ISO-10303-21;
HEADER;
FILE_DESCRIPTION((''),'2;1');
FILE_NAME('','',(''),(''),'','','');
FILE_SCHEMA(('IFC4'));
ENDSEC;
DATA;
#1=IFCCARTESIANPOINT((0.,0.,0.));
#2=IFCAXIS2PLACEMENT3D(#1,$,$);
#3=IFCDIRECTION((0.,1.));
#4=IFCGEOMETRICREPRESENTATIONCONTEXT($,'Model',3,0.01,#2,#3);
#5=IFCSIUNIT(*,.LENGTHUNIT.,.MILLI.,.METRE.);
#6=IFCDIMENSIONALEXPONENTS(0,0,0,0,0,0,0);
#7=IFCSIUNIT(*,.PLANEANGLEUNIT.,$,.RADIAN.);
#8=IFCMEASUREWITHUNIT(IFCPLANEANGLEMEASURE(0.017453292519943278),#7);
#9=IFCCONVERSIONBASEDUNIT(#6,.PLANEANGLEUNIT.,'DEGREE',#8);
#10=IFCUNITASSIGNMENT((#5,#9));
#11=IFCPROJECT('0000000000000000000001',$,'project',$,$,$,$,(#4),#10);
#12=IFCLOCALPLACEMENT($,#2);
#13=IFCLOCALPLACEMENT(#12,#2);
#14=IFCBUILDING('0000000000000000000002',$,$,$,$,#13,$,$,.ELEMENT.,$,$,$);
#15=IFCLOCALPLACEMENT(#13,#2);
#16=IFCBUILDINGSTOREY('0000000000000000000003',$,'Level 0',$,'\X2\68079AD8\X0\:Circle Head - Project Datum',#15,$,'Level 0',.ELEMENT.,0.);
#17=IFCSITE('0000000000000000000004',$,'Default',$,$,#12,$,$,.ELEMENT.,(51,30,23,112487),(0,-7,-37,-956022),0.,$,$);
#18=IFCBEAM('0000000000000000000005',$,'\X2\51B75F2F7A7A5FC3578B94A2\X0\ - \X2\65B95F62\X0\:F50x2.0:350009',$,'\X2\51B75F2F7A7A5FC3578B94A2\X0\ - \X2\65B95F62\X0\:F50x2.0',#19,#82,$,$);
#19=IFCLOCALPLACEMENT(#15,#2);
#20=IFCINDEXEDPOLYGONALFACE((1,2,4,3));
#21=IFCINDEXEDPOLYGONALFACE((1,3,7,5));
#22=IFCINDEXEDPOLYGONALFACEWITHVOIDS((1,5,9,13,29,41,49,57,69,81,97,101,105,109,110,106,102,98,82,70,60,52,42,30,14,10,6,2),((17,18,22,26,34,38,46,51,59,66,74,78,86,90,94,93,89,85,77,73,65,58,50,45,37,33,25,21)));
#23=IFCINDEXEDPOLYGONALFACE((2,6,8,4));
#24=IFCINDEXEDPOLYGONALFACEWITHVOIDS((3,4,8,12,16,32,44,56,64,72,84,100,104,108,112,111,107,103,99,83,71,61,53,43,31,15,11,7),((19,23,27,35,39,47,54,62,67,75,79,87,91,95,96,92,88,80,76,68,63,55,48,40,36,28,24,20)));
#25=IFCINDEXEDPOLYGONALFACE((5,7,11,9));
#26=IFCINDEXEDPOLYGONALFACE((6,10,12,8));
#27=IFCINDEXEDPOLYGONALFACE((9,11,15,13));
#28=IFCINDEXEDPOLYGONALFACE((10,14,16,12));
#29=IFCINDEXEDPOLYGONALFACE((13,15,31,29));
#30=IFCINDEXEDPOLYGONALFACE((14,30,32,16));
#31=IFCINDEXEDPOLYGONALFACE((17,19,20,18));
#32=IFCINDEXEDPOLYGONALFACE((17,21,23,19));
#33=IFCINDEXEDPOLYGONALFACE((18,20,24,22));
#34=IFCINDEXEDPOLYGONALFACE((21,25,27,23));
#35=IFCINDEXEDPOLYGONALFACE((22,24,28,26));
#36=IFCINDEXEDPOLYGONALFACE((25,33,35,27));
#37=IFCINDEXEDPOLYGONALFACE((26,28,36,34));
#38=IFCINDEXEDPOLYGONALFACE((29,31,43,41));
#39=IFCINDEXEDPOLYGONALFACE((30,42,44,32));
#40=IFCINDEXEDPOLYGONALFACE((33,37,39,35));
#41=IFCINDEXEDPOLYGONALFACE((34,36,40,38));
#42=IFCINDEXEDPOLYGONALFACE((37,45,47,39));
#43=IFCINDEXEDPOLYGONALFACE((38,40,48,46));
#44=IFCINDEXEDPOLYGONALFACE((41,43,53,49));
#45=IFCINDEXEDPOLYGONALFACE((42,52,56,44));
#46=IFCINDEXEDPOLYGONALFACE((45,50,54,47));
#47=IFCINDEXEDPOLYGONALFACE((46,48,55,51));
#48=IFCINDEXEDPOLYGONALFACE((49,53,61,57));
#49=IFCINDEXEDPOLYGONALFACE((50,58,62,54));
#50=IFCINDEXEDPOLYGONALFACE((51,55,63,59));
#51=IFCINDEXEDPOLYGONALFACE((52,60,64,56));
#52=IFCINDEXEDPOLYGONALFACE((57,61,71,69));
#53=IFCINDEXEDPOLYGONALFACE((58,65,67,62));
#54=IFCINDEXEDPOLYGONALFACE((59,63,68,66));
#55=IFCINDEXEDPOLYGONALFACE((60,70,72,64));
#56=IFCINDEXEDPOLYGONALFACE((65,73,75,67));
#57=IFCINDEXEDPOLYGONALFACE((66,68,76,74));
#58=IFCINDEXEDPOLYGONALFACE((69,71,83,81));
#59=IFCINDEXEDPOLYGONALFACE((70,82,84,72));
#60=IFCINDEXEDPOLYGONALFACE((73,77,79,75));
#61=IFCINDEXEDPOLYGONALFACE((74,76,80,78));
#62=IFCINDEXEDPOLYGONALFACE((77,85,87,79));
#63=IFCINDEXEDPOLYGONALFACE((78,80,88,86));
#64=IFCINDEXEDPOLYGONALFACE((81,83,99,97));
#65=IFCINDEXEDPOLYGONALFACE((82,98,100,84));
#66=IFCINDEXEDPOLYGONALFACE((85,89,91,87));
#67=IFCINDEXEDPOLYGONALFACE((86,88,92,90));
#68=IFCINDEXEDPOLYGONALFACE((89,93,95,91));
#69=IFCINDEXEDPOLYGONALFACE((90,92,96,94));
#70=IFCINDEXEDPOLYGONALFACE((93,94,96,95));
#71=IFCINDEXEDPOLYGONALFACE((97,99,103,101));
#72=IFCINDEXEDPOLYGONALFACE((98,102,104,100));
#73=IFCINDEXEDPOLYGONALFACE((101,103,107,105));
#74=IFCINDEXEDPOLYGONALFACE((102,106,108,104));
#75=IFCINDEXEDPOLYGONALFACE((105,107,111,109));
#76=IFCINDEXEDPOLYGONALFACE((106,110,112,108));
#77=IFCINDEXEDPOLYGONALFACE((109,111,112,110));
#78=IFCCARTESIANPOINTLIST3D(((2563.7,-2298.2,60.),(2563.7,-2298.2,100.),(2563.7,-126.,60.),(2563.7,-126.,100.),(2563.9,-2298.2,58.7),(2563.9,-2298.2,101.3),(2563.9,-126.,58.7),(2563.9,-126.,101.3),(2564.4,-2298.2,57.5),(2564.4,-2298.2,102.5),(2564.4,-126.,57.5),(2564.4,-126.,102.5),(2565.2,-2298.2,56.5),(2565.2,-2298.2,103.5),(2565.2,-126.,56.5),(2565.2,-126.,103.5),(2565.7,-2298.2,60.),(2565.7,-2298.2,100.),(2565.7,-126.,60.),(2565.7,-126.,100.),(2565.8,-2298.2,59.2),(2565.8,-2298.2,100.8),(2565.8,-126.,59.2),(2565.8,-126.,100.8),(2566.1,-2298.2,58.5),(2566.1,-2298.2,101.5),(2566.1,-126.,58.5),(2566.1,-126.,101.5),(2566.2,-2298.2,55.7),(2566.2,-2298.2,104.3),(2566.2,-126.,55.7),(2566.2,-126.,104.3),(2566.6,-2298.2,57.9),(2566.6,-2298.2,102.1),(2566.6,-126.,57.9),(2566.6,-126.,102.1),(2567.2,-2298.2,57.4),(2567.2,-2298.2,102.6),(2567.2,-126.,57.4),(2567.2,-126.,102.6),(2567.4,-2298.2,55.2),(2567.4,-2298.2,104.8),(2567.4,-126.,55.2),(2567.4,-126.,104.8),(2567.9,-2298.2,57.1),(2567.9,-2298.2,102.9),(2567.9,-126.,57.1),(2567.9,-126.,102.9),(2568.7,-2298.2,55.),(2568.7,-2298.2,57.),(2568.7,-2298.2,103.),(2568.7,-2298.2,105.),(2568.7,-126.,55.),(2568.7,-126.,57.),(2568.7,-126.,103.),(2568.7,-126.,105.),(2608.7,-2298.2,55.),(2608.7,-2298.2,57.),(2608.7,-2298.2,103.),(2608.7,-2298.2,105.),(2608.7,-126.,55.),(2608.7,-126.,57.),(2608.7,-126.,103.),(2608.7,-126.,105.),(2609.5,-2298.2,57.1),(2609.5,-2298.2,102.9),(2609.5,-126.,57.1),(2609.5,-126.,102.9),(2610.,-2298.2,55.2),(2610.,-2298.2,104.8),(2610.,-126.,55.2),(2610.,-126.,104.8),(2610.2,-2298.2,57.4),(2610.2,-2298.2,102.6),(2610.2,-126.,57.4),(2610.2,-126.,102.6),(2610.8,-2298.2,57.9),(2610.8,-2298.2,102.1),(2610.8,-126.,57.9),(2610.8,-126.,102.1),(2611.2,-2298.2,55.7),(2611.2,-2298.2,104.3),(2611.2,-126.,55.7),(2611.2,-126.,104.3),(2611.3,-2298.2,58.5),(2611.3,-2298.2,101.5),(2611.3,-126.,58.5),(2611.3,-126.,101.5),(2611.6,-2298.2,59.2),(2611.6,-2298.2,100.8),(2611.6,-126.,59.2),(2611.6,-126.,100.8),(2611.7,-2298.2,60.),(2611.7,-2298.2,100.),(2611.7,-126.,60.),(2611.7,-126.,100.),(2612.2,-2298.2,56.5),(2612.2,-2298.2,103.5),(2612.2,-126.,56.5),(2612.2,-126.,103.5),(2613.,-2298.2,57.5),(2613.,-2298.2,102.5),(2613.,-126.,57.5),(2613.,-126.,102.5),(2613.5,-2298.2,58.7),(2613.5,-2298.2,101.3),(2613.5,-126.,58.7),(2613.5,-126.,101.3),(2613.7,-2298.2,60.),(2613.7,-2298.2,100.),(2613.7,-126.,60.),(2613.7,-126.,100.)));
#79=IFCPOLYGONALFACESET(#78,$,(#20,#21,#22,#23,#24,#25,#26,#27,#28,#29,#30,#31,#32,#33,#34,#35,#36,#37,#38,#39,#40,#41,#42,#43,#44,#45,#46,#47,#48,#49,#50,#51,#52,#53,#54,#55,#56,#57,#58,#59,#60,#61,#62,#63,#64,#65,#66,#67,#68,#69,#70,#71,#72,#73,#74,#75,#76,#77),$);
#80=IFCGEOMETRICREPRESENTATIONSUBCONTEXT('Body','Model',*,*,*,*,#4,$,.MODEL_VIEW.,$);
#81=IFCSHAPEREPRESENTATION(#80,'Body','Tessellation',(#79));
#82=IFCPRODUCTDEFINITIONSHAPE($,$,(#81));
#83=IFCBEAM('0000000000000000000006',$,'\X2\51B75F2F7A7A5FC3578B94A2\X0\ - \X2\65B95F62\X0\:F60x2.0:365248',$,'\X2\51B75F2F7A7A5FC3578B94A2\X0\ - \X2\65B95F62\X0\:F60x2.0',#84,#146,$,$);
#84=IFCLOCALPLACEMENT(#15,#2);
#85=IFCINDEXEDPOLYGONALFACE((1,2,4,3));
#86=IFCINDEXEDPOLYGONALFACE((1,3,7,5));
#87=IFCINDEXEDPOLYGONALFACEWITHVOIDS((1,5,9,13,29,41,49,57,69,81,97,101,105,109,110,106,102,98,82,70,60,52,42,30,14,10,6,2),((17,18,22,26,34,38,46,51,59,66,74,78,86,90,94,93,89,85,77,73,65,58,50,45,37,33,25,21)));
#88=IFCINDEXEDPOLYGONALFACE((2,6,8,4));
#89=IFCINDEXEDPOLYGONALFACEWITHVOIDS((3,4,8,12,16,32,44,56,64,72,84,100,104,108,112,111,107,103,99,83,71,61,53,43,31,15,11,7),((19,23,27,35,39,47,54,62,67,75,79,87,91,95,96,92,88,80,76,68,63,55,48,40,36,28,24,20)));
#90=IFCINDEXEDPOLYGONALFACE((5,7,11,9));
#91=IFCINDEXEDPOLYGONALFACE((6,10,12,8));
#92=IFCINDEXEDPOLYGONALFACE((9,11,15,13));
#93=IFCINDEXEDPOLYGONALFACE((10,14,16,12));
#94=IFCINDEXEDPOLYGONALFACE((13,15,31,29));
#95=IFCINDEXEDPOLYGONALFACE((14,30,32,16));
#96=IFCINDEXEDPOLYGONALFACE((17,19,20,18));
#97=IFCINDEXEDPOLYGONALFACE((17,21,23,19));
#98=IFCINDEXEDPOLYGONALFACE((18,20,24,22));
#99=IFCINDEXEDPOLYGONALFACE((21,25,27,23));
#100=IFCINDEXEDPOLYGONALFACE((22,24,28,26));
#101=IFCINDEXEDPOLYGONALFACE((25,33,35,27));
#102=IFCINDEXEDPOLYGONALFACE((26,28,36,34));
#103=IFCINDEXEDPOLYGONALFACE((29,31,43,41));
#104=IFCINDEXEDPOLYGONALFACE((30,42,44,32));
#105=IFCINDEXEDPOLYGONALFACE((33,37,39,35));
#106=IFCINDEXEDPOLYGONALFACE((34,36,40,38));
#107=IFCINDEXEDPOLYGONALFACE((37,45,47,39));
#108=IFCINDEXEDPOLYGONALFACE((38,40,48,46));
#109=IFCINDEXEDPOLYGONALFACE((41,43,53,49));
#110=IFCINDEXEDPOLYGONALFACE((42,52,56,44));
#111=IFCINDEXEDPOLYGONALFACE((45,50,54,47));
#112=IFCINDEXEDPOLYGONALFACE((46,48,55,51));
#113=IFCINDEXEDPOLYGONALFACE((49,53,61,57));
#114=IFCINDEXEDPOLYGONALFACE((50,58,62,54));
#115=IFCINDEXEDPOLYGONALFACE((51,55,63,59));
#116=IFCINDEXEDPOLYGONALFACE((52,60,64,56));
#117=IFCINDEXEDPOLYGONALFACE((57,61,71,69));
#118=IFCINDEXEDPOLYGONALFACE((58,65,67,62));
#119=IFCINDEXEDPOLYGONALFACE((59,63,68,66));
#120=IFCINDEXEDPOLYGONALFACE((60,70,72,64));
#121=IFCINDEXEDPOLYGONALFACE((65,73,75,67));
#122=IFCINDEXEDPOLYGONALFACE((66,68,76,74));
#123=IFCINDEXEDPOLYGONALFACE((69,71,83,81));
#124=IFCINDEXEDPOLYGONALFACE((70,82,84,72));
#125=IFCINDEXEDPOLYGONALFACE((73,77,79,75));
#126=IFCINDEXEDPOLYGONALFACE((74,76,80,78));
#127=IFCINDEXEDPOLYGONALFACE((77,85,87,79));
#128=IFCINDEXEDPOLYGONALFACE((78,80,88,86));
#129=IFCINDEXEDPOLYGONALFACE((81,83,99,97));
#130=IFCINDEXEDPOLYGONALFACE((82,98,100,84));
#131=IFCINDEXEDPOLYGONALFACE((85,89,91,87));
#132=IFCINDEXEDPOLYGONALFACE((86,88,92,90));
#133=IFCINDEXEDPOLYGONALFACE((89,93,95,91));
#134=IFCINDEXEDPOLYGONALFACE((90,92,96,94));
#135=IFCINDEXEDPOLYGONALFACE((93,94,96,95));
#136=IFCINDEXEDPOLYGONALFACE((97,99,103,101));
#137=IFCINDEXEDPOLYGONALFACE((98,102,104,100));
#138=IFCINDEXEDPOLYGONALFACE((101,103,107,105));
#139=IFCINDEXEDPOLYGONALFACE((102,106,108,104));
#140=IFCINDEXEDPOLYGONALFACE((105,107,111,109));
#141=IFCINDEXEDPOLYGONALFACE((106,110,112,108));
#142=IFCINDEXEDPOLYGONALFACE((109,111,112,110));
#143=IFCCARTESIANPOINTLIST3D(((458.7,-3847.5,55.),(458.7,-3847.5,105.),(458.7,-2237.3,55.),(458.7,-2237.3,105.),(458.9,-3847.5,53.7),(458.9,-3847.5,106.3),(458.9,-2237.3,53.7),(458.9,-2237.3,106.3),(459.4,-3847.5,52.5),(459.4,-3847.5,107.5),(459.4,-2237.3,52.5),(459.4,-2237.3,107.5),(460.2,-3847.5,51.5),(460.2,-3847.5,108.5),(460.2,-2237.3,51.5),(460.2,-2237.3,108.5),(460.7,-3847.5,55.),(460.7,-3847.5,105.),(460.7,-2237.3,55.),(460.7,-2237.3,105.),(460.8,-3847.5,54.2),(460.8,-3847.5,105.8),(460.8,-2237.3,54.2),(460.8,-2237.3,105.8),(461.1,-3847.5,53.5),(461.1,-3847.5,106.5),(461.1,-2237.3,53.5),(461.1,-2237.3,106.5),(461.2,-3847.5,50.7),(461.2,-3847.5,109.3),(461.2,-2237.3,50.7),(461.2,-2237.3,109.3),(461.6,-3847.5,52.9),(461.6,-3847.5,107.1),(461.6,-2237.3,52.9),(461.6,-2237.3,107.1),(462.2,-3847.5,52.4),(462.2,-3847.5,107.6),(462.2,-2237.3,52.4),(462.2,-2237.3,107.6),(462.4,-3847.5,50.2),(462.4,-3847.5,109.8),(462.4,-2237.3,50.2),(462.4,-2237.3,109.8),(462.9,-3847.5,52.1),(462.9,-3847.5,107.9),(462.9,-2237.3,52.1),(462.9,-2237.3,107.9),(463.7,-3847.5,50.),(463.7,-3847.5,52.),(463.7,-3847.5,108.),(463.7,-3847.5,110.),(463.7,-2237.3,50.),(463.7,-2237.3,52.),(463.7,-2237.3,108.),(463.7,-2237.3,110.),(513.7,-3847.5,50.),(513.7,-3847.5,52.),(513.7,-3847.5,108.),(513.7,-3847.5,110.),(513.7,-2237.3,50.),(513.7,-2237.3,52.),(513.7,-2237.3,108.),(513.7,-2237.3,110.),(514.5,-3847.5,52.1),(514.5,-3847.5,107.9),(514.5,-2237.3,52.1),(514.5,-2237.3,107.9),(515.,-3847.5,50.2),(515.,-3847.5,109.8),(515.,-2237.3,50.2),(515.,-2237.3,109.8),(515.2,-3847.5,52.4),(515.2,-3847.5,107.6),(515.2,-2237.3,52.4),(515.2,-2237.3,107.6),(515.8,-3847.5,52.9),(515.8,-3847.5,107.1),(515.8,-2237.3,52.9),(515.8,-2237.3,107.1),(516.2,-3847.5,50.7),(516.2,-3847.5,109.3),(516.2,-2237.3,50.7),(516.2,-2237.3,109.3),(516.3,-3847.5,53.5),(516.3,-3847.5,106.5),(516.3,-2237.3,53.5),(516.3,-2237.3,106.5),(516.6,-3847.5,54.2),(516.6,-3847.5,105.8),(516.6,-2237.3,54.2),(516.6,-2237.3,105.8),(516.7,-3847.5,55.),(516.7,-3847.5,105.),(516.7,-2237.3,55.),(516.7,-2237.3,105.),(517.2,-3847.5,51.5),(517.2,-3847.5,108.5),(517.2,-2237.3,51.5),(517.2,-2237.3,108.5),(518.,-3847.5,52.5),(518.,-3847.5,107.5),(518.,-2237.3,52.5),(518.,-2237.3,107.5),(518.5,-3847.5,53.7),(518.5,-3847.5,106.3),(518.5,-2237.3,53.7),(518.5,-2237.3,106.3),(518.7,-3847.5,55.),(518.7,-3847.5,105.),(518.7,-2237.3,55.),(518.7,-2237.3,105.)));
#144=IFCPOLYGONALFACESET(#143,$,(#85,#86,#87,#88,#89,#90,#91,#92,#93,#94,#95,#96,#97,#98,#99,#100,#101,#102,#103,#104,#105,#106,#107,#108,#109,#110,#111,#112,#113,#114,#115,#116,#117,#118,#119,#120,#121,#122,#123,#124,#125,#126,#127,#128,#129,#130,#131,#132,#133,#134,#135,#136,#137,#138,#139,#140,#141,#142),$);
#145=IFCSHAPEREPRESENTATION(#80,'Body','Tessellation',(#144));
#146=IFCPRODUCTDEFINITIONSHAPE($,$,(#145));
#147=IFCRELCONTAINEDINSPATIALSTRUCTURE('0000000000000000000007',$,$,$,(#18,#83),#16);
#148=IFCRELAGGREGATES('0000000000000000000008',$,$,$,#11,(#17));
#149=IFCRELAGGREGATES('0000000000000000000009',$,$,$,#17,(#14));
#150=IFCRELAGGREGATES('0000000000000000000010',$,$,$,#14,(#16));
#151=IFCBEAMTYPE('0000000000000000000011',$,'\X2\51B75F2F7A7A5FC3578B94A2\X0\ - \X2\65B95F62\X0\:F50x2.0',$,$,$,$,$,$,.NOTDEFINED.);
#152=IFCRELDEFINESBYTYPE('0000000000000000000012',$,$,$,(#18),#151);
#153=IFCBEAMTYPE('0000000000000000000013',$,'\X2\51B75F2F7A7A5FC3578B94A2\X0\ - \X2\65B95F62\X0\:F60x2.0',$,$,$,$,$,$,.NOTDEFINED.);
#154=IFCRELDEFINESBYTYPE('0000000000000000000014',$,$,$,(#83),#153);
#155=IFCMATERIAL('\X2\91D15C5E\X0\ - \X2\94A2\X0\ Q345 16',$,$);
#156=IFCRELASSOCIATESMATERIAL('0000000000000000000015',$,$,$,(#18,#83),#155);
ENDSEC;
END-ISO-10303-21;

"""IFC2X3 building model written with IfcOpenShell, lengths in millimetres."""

from ifc_helpers import new_model, entity, si_unit, converted_unit, direction, frame, frame_2d, origin, place, context, subcontext, project, spatial, polyline, circle_curve, parameter, trimmed, segment, composite_curve, outline, extrude, material, type_object, element, save


model = new_model("IFC2X3")

# Units and contexts
model_context = context("Model", 3, precision=0.01, world=origin(), true_north=direction((0.0, 1.0)))
body_context = subcontext(model_context, "Body", "Model", "MODEL_VIEW")
ifc_project = project(units=[si_unit("LENGTHUNIT", "METRE", prefix="MILLI"), converted_unit("PLANEANGLEUNIT", "DEGREE", entity("IfcPlaneAngleMeasure", 0.017453292519943278), si_unit("PLANEANGLEUNIT", "RADIAN"), dimensions=[0, 0, 0, 0, 0, 0, 0])], contexts=[model_context])

# Site, building, storey
site_placement = place(None, origin())
site = spatial("IfcSite", under=ifc_project, at=site_placement, Name="Default", CompositionType="ELEMENT", RefLatitude=(51, 30, 23, 112487), RefLongitude=(0, -7, -37, -956022), RefElevation=0.0)
building_placement = place(site_placement, origin())
building = spatial("IfcBuilding", under=site, at=building_placement, CompositionType="ELEMENT")
storey_placement = place(building_placement, origin())
storey = spatial("IfcBuildingStorey", under=building, at=storey_placement, Name="Level 0", ObjectType="标高:Circle Head - Project Datum", LongName="Level 0", CompositionType="ELEMENT", Elevation=0.0)

# Beams
ifc_material_1 = material(Name="金属 - 钢 Q345 16")
beam_type_1 = type_object("IfcBeamType", Name="冷弯空心型钢 - 方形:F50x2.0", PredefinedType="NOTDEFINED")
beam_1_placement = place(storey_placement, frame((2588.7, -390.5, 105.0), z_axis=(0.0, 0.0, 1.0), x_axis=(0.0, -1.0, 0.0)))
element("IfcBeam", 1, at=beam_1_placement, inside=storey, type_object=beam_type_1, material=ifc_material_1, Name="冷弯空心型钢 - 方形:F50x2.0:350009", ObjectType="冷弯空心型钢 - 方形:F50x2.0", context=body_context, shape_type="SweptSolid", body=[
    extrude(outline(composite_curve([segment(trimmed(circle_curve(frame_2d((-20.0, 20.0), x_axis=(1.0, 0.0)), 5.0), [parameter(90.0)], [parameter(180.0)], True, "PARAMETER"), True, "CONTINUOUS"), segment(polyline([(-25.0, 20.0), (-25.0, -20.0)]), True, "CONTINUOUS"), segment(trimmed(circle_curve(frame_2d((-20.0, -20.0), x_axis=(1.0, 0.0)), 5.0), [parameter(180.0)], [parameter(270.0)], True, "PARAMETER"), True, "CONTINUOUS"), segment(polyline([(-20.0, -25.0), (20.0, -25.0)]), True, "CONTINUOUS"), segment(trimmed(circle_curve(frame_2d((20.0, -20.0), x_axis=(1.0, 0.0)), 5.0), [parameter(270.0)], [parameter(0.0)], True, "PARAMETER"), True, "CONTINUOUS"), segment(polyline([(25.0, -20.0), (25.0, 20.0)]), True, "CONTINUOUS"), segment(trimmed(circle_curve(frame_2d((20.0, 20.0), x_axis=(1.0, 0.0)), 5.0), [parameter(0.0)], [parameter(90.0)], True, "PARAMETER"), True, "CONTINUOUS"), segment(polyline([(20.0, 25.0), (-20.0, 25.0)]), True, "CONTINUOUS")], self_intersect=False), holes=[composite_curve([segment(polyline([(-20.0, 23.0), (20.0, 23.0)]), True, "CONTINUOUS"), segment(trimmed(circle_curve(frame_2d((20.0, 20.0), x_axis=(1.0, 0.0)), 3.0), [parameter(360.0)], [parameter(90.0)], True, "PARAMETER"), False, "CONTINUOUS"), segment(polyline([(23.0, 20.0), (23.0, -20.0)]), True, "CONTINUOUS"), segment(trimmed(circle_curve(frame_2d((20.0, -20.0), x_axis=(1.0, 0.0)), 3.0), [parameter(270.0)], [parameter(360.0)], True, "PARAMETER"), False, "CONTINUOUS"), segment(polyline([(20.0, -23.0), (-20.0, -23.0)]), True, "CONTINUOUS"), segment(trimmed(circle_curve(frame_2d((-20.0, -20.0), x_axis=(1.0, 0.0)), 3.0), [parameter(180.0)], [parameter(270.0)], True, "PARAMETER"), False, "CONTINUOUS"), segment(polyline([(-23.0, -20.0), (-23.0, 20.0)]), True, "CONTINUOUS"), segment(trimmed(circle_curve(frame_2d((-20.0, 20.0), x_axis=(1.0, 0.0)), 3.0), [parameter(90.0)], [parameter(180.0)], True, "PARAMETER"), False, "CONTINUOUS")], self_intersect=False)]), frame((-264.5, 0.0, -25.0), z_axis=(1.0, 0.0, 0.0), x_axis=(0.0, 1.0, 0.0)), (0.0, 0.0, 1.0), 2172.2),
])
beam_type_2 = type_object("IfcBeamType", Name="冷弯空心型钢 - 方形:F60x2.0", PredefinedType="NOTDEFINED")
beam_2_placement = place(storey_placement, frame((488.7, -3815.6, 110.0), z_axis=(0.0, 0.0, 1.0), x_axis=(0.0, 1.0, 0.0)))
element("IfcBeam", 2, at=beam_2_placement, inside=storey, type_object=beam_type_2, material=ifc_material_1, Name="冷弯空心型钢 - 方形:F60x2.0:365248", ObjectType="冷弯空心型钢 - 方形:F60x2.0", context=body_context, shape_type="SweptSolid", body=[
    extrude(outline(composite_curve([segment(polyline([(-25.0, -30.0), (25.0, -30.0)]), True, "CONTINUOUS"), segment(trimmed(circle_curve(frame_2d((25.0, -25.0), x_axis=(1.0, 0.0)), 5.0), [parameter(270.0)], [parameter(360.0)], True, "PARAMETER"), True, "CONTINUOUS"), segment(polyline([(30.0, -25.0), (30.0, 25.0)]), True, "CONTINUOUS"), segment(trimmed(circle_curve(frame_2d((25.0, 25.0), x_axis=(1.0, 0.0)), 5.0), [parameter(360.0)], [parameter(90.0)], True, "PARAMETER"), True, "CONTINUOUS"), segment(polyline([(25.0, 30.0), (-25.0, 30.0)]), True, "CONTINUOUS"), segment(trimmed(circle_curve(frame_2d((-25.0, 25.0), x_axis=(1.0, 0.0)), 5.0), [parameter(90.0)], [parameter(180.0)], True, "PARAMETER"), True, "CONTINUOUS"), segment(polyline([(-30.0, 25.0), (-30.0, -25.0)]), True, "CONTINUOUS"), segment(trimmed(circle_curve(frame_2d((-25.0, -25.0), x_axis=(1.0, 0.0)), 5.0), [parameter(180.0)], [parameter(270.0)], True, "PARAMETER"), True, "CONTINUOUS")], self_intersect=False), holes=[composite_curve([segment(trimmed(circle_curve(frame_2d((-25.0, -25.0), x_axis=(1.0, 0.0)), 3.0), [parameter(180.0)], [parameter(270.0)], True, "PARAMETER"), False, "CONTINUOUS"), segment(polyline([(-28.0, -25.0), (-28.0, 25.0)]), True, "CONTINUOUS"), segment(trimmed(circle_curve(frame_2d((-25.0, 25.0), x_axis=(1.0, 0.0)), 3.0), [parameter(90.0)], [parameter(180.0)], True, "PARAMETER"), False, "CONTINUOUS"), segment(polyline([(-25.0, 28.0), (25.0, 28.0)]), True, "CONTINUOUS"), segment(trimmed(circle_curve(frame_2d((25.0, 25.0), x_axis=(1.0, 0.0)), 3.0), [parameter(0.0)], [parameter(90.0)], True, "PARAMETER"), False, "CONTINUOUS"), segment(polyline([(28.0, 25.0), (28.0, -25.0)]), True, "CONTINUOUS"), segment(trimmed(circle_curve(frame_2d((25.0, -25.0), x_axis=(1.0, 0.0)), 3.0), [parameter(270.0)], [parameter(360.0)], True, "PARAMETER"), False, "CONTINUOUS"), segment(polyline([(25.0, -28.0), (-25.0, -28.0)]), True, "CONTINUOUS")], self_intersect=False)]), frame((-31.9, 0.0, -30.0), z_axis=(1.0, 0.0, 0.0), x_axis=(0.0, -1.0, 0.0)), (0.0, 0.0, 1.0), 1610.2),
])

save(model, "model.ifc")
